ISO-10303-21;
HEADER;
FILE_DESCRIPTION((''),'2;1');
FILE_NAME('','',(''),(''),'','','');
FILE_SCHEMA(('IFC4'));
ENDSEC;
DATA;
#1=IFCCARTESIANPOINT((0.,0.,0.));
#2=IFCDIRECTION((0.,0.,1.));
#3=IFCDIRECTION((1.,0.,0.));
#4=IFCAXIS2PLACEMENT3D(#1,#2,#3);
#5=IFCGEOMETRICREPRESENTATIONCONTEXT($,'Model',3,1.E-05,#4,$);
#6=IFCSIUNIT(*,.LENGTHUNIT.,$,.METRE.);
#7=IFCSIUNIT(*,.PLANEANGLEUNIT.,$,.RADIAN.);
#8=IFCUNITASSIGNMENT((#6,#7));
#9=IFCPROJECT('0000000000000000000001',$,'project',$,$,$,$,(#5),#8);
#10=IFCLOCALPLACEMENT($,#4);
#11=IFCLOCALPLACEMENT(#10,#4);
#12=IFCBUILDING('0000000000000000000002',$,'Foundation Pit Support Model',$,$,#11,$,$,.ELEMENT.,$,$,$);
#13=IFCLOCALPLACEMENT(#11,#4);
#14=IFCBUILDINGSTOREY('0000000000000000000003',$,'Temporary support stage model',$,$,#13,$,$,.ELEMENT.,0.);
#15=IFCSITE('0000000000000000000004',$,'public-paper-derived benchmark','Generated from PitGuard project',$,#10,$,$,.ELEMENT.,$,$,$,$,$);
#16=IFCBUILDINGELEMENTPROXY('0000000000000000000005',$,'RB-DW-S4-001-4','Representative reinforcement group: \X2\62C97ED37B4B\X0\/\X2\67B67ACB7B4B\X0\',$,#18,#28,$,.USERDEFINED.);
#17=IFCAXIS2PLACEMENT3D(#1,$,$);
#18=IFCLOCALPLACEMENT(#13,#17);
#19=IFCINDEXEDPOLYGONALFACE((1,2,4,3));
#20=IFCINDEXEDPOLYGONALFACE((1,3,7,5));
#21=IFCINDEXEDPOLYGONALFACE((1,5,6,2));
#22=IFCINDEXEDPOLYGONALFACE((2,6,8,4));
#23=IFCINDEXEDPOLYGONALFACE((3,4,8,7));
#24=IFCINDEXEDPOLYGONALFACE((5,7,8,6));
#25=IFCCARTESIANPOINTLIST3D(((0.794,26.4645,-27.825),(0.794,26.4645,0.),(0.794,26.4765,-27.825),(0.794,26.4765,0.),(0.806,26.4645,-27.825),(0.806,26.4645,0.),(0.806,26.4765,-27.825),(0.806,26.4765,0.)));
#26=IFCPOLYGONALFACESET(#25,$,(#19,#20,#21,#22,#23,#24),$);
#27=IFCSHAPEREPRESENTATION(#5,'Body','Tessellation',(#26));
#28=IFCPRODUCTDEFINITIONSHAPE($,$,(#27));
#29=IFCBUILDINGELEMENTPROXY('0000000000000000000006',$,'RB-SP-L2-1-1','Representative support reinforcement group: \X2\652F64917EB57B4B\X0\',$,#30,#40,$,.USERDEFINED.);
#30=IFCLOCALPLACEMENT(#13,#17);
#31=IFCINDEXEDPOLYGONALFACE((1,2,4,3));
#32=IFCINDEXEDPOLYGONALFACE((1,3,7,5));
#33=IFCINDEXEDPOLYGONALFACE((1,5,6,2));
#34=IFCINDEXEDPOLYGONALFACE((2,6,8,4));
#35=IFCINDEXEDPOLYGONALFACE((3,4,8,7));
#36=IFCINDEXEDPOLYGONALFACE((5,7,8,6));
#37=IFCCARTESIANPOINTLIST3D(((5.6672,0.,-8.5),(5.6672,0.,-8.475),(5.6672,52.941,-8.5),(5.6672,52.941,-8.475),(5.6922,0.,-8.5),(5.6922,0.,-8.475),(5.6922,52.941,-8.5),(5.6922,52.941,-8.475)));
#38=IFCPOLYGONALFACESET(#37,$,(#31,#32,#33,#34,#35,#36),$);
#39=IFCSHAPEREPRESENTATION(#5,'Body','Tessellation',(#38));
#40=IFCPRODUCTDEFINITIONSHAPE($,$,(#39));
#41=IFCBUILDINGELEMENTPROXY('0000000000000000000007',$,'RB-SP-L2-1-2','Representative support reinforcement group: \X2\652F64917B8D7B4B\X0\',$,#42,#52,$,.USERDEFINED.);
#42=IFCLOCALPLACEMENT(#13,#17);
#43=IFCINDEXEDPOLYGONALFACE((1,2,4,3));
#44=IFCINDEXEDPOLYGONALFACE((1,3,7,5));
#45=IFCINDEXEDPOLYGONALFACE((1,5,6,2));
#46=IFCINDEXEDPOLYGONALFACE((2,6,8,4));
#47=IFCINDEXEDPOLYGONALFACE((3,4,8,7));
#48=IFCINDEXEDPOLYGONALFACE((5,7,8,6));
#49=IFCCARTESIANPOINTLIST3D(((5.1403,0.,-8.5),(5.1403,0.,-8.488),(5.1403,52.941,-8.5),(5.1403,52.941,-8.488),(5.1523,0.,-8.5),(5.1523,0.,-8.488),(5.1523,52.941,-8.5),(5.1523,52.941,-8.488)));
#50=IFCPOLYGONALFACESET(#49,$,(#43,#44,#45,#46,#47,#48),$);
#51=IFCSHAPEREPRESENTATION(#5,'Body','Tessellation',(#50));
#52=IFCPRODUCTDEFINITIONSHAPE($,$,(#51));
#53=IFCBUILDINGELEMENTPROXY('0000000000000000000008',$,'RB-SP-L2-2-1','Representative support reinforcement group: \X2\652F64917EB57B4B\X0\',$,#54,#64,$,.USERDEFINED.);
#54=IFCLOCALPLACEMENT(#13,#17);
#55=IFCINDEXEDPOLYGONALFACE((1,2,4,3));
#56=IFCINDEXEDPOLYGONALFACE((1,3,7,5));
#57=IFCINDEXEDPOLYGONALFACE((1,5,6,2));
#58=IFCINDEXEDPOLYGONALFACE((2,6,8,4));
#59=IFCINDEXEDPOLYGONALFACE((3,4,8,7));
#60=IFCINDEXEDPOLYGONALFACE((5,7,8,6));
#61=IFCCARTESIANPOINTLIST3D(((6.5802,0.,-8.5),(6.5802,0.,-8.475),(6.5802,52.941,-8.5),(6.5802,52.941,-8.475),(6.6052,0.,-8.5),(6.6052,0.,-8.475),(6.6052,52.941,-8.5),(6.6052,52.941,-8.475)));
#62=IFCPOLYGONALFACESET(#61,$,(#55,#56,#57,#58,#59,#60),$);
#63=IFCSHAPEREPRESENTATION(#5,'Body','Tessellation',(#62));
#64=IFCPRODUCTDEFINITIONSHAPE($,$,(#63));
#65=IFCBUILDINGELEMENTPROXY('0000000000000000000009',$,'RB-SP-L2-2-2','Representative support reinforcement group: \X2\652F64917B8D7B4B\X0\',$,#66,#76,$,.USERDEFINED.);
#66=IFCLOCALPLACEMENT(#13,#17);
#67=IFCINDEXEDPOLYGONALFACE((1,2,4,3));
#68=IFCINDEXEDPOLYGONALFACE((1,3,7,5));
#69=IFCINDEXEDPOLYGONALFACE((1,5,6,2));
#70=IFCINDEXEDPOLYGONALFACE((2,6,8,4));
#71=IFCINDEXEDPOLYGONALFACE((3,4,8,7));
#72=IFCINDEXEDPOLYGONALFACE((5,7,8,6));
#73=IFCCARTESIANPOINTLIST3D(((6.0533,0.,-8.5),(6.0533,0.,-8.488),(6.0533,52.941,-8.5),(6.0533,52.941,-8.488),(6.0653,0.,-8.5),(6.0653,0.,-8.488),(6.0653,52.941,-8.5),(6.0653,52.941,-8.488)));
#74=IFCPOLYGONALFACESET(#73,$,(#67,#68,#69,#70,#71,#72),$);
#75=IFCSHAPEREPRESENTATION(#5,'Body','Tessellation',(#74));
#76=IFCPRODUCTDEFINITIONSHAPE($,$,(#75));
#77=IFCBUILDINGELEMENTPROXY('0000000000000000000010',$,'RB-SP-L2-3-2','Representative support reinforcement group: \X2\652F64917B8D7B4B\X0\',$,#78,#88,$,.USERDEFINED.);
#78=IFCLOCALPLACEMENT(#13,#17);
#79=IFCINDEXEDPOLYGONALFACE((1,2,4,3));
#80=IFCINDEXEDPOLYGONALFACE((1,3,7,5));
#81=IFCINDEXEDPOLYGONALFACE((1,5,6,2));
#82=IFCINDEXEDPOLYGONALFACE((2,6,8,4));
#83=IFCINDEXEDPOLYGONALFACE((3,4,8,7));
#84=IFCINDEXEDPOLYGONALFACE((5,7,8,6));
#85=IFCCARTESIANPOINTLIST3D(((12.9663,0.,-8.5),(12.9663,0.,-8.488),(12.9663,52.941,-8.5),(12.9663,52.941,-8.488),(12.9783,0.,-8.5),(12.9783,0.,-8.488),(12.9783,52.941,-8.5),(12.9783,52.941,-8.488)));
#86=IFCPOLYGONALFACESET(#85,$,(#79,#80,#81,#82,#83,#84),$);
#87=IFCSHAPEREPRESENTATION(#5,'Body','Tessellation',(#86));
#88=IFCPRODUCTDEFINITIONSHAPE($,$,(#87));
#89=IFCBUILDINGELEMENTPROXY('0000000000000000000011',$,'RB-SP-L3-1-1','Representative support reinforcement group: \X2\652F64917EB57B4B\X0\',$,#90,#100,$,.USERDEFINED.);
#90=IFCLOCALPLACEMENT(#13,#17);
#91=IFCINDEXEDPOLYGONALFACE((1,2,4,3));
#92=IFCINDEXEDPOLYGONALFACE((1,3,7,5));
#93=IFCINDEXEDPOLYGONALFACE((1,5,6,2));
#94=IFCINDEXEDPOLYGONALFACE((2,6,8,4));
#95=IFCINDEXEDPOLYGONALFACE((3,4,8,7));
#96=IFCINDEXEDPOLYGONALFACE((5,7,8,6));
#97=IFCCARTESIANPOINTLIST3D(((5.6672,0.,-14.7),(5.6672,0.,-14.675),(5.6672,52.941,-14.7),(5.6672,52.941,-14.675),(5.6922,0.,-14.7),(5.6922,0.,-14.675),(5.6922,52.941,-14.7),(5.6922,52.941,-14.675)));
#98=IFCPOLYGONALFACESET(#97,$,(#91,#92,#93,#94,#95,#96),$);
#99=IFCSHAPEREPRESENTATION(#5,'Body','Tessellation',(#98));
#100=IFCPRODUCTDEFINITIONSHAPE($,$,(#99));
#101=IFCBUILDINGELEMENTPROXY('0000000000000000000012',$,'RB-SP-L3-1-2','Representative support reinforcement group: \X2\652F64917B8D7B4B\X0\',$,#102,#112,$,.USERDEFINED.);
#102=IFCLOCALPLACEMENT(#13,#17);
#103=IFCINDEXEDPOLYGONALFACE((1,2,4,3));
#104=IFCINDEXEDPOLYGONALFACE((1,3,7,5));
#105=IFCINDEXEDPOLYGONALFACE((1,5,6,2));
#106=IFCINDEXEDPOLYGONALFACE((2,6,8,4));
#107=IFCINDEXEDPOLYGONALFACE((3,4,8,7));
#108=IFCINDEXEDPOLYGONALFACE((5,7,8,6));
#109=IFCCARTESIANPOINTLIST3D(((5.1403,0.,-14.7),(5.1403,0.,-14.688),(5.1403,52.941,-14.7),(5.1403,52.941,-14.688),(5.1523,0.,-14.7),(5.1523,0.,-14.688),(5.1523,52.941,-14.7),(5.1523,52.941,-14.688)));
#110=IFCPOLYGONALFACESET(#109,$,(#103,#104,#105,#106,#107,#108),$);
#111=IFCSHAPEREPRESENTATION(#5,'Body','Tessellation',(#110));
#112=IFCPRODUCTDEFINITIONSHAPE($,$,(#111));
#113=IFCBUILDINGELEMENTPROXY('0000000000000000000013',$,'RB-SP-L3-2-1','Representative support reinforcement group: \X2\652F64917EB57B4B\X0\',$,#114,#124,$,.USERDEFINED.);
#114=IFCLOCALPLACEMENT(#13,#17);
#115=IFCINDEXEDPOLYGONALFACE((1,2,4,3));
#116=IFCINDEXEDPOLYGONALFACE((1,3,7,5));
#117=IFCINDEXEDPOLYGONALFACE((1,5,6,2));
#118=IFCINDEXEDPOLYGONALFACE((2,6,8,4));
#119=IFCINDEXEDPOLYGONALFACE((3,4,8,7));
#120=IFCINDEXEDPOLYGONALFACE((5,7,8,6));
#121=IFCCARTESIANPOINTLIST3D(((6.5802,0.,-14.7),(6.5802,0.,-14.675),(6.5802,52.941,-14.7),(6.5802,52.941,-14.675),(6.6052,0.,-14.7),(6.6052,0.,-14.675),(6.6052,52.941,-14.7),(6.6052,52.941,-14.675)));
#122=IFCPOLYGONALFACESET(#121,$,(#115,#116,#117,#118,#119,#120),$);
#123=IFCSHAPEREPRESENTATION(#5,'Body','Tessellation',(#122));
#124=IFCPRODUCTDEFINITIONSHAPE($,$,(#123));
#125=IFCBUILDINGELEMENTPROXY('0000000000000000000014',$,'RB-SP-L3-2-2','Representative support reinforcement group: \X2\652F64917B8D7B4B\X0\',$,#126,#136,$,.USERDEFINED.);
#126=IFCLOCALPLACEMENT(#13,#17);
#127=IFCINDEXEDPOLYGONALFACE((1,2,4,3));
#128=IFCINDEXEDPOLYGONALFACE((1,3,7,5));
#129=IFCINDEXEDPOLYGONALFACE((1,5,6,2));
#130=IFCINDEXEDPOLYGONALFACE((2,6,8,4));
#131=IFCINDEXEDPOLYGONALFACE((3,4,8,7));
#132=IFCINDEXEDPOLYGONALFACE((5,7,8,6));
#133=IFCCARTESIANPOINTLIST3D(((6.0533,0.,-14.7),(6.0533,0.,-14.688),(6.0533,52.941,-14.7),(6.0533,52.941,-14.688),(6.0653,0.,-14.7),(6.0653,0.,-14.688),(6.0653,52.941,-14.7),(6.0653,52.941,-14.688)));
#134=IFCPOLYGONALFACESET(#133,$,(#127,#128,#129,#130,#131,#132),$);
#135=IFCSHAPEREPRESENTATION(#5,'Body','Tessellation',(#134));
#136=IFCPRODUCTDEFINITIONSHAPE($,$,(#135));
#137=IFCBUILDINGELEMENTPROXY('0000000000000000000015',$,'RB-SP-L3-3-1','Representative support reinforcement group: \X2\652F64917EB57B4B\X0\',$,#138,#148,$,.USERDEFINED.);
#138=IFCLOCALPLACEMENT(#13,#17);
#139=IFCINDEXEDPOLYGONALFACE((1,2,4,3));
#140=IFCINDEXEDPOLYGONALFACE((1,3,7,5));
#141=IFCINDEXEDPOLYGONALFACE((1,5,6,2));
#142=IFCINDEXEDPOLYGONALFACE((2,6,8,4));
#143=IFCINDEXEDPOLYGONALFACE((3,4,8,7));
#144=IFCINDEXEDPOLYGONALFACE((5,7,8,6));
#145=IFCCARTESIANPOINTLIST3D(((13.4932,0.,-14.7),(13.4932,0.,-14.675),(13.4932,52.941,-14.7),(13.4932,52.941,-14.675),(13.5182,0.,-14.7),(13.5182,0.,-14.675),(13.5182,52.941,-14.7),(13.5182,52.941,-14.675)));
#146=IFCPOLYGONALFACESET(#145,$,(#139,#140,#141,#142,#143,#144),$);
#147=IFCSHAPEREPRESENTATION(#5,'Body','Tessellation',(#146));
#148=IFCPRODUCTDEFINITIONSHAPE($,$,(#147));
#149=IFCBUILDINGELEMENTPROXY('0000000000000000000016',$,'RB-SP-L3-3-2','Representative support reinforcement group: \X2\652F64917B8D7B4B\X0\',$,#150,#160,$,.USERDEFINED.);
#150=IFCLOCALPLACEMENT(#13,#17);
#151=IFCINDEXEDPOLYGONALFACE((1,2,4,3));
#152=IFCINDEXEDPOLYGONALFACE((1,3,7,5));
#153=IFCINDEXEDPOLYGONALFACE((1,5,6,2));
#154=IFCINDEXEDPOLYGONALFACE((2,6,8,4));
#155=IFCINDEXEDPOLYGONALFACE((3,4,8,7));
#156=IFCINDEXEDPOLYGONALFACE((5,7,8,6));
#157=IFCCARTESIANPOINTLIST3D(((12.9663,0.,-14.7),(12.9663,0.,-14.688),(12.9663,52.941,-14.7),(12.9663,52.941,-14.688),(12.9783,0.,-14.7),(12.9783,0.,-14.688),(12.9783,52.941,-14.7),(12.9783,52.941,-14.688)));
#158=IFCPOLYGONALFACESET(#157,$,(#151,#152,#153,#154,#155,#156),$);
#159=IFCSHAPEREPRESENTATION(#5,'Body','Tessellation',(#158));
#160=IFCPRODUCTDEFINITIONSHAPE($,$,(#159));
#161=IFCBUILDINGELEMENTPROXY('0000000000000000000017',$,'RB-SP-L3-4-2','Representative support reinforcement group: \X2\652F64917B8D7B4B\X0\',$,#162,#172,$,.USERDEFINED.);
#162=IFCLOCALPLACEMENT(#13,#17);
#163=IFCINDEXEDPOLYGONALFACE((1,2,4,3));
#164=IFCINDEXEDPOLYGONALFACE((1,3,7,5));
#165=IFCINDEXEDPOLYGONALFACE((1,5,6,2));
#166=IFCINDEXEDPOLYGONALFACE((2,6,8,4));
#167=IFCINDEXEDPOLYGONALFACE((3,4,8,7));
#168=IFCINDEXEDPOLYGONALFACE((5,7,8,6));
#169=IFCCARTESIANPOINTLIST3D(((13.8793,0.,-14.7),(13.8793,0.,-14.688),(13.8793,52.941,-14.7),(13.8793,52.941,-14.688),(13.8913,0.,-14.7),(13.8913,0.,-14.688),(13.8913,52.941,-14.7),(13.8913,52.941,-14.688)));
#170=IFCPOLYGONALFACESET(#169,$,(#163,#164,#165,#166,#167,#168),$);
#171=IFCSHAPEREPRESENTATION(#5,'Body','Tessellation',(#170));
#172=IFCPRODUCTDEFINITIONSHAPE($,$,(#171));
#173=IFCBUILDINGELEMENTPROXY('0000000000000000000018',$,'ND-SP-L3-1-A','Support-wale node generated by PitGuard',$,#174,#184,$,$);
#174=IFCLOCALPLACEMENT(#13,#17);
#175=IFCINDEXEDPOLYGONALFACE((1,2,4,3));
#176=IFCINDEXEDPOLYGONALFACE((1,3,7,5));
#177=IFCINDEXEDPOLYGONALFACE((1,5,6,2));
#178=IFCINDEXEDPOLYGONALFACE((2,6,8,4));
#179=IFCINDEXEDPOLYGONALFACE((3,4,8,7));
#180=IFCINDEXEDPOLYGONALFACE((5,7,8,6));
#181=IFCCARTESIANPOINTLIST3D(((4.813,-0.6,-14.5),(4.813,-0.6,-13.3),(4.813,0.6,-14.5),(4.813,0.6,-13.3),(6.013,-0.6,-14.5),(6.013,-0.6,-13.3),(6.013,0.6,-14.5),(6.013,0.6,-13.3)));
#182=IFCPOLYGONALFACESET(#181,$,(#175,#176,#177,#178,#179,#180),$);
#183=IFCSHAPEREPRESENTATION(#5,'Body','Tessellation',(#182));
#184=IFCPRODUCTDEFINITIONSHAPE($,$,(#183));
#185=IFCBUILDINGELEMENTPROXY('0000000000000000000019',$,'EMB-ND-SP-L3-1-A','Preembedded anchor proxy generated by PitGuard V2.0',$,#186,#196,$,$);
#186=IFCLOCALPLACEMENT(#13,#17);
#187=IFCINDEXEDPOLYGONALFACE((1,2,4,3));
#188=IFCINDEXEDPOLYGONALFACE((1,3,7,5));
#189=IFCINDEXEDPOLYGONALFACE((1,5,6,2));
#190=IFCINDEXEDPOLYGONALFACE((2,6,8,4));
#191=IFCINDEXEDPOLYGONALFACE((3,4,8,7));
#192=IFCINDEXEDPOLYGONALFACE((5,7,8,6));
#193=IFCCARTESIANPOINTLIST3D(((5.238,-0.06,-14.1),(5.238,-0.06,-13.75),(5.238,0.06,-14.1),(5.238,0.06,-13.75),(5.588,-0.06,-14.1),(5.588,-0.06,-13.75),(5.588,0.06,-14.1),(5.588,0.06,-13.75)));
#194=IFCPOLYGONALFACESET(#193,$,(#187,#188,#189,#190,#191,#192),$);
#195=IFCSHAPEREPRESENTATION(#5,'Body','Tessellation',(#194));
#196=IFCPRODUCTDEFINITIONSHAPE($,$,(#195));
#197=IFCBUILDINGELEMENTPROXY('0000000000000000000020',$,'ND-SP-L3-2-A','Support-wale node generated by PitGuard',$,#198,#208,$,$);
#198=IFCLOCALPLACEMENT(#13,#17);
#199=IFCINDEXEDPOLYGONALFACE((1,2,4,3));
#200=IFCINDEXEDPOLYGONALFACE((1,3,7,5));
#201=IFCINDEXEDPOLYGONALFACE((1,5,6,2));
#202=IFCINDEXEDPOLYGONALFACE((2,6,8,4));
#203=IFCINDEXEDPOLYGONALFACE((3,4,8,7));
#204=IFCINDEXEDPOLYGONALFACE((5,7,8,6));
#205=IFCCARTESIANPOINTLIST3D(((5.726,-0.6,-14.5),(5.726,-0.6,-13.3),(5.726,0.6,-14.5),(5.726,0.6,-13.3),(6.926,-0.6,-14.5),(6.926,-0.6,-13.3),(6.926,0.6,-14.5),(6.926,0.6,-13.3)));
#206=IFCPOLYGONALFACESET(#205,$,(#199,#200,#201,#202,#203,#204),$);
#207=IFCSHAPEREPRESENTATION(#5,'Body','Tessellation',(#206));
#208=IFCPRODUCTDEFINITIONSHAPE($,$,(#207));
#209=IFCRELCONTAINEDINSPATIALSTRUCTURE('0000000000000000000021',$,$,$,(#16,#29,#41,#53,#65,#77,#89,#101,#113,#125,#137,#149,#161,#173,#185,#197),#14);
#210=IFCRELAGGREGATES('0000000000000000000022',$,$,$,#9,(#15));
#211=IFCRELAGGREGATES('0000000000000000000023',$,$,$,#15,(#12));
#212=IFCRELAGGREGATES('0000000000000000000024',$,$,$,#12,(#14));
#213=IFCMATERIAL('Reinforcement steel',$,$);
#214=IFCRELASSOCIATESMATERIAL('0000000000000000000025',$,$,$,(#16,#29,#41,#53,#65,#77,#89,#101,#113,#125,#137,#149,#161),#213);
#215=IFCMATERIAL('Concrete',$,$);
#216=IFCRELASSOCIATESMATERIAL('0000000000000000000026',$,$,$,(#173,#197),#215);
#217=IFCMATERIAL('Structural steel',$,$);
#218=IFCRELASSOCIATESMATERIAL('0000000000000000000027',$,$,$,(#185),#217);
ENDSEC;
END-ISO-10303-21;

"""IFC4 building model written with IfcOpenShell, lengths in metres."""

from ifc_helpers import new_model, si_unit, frame, origin_with_axes, origin_2d, place, context, project, spatial, rectangle, extrude, material, element, save


model = new_model("IFC4")

# Units and contexts
model_context = context("Model", 3, precision=1e-05, world=origin_with_axes())
ifc_project = project(units=[si_unit("LENGTHUNIT", "METRE"), si_unit("PLANEANGLEUNIT", "RADIAN")], contexts=[model_context])

# Site, building, storey
site_placement = place(None, origin_with_axes())
site = spatial("IfcSite", under=ifc_project, at=site_placement, Name="public-paper-derived benchmark", Description="Generated from PitGuard project", CompositionType="ELEMENT")
building_placement = place(site_placement, origin_with_axes())
building = spatial("IfcBuilding", under=site, at=building_placement, Name="Foundation Pit Support Model", CompositionType="ELEMENT")
storey_placement = place(building_placement, origin_with_axes())
storey = spatial("IfcBuildingStorey", under=building, at=storey_placement, Name="Temporary support stage model", CompositionType="ELEMENT", Elevation=0.0)

# Shared definitions
ifc_material_1 = material(Name="Structural steel")

# Shared definitions
ifc_material_2 = material(Name="Concrete")

# Building element proxies
ifc_material_3 = material(Name="Reinforcement steel")
proxy_1_placement = place(storey_placement, frame((0.8, 26.4705, -27.825), z_axis=(0.0, 0.0, 1.0), x_axis=(1.0, 0.0, 0.0)))
element("IfcBuildingElementProxy", 1, at=proxy_1_placement, inside=storey, material=ifc_material_3, Name="RB-DW-S4-001-4", Description="Representative reinforcement group: 拉结筋/架立筋", PredefinedType="USERDEFINED", context=model_context, shape_type="SweptSolid", body=[
    extrude(rectangle(XDim=0.012, YDim=0.012, at=origin_2d()), origin_with_axes(), (0.0, 0.0, 1.0), 27.825),
])
proxy_2_placement = place(storey_placement, frame((5.6797, 26.4705, -8.5), z_axis=(0.0, 0.0, 1.0), x_axis=(0.0, 1.0, 0.0)))
element("IfcBuildingElementProxy", 2, at=proxy_2_placement, inside=storey, material=ifc_material_3, Name="RB-SP-L2-1-1", Description="Representative support reinforcement group: 支撑纵筋", PredefinedType="USERDEFINED", context=model_context, shape_type="SweptSolid", body=[
    extrude(rectangle(XDim=52.941, YDim=0.025, at=origin_2d()), origin_with_axes(), (0.0, 0.0, 1.0), 0.025),
])
proxy_3_placement = place(storey_placement, frame((5.1463, 26.4705, -8.5), z_axis=(0.0, 0.0, 1.0), x_axis=(0.0, 1.0, 0.0)))
element("IfcBuildingElementProxy", 3, at=proxy_3_placement, inside=storey, material=ifc_material_3, Name="RB-SP-L2-1-2", Description="Representative support reinforcement group: 支撑箍筋", PredefinedType="USERDEFINED", context=model_context, shape_type="SweptSolid", body=[
    extrude(rectangle(XDim=52.941, YDim=0.012, at=origin_2d()), origin_with_axes(), (0.0, 0.0, 1.0), 0.012),
])
proxy_4_placement = place(storey_placement, frame((6.5927, 26.4705, -8.5), z_axis=(0.0, 0.0, 1.0), x_axis=(0.0, 1.0, 0.0)))
element("IfcBuildingElementProxy", 4, at=proxy_4_placement, inside=storey, material=ifc_material_3, Name="RB-SP-L2-2-1", Description="Representative support reinforcement group: 支撑纵筋", PredefinedType="USERDEFINED", context=model_context, shape_type="SweptSolid", body=[
    extrude(rectangle(XDim=52.941, YDim=0.025, at=origin_2d()), origin_with_axes(), (0.0, 0.0, 1.0), 0.025),
])
for number, where, z_axis, x_axis, name in (
    (5, (6.0593, 26.4705, -8.5), (0.0, 0.0, 1.0), (0.0, 1.0, 0.0), "RB-SP-L2-2-2"),
    (6, (12.9723, 26.4705, -8.5), (0.0, 0.0, 1.0), (0.0, 1.0, 0.0), "RB-SP-L2-3-2"),
):
    element("IfcBuildingElementProxy", number, at=place(storey_placement, frame(where, z_axis=z_axis, x_axis=x_axis)), inside=storey, material=ifc_material_3, Name=name, Description="Representative support reinforcement group: 支撑箍筋", PredefinedType="USERDEFINED", context=model_context, shape_type="SweptSolid", body=[
        extrude(rectangle(XDim=52.941, YDim=0.012, at=origin_2d()), origin_with_axes(), (0.0, 0.0, 1.0), 0.012),
    ])
proxy_5_placement = place(storey_placement, frame((5.6797, 26.4705, -14.7), z_axis=(0.0, 0.0, 1.0), x_axis=(0.0, 1.0, 0.0)))
element("IfcBuildingElementProxy", 7, at=proxy_5_placement, inside=storey, material=ifc_material_3, Name="RB-SP-L3-1-1", Description="Representative support reinforcement group: 支撑纵筋", PredefinedType="USERDEFINED", context=model_context, shape_type="SweptSolid", body=[
    extrude(rectangle(XDim=52.941, YDim=0.025, at=origin_2d()), origin_with_axes(), (0.0, 0.0, 1.0), 0.025),
])
proxy_6_placement = place(storey_placement, frame((5.1463, 26.4705, -14.7), z_axis=(0.0, 0.0, 1.0), x_axis=(0.0, 1.0, 0.0)))
element("IfcBuildingElementProxy", 8, at=proxy_6_placement, inside=storey, material=ifc_material_3, Name="RB-SP-L3-1-2", Description="Representative support reinforcement group: 支撑箍筋", PredefinedType="USERDEFINED", context=model_context, shape_type="SweptSolid", body=[
    extrude(rectangle(XDim=52.941, YDim=0.012, at=origin_2d()), origin_with_axes(), (0.0, 0.0, 1.0), 0.012),
])
proxy_7_placement = place(storey_placement, frame((6.5927, 26.4705, -14.7), z_axis=(0.0, 0.0, 1.0), x_axis=(0.0, 1.0, 0.0)))
element("IfcBuildingElementProxy", 9, at=proxy_7_placement, inside=storey, material=ifc_material_3, Name="RB-SP-L3-2-1", Description="Representative support reinforcement group: 支撑纵筋", PredefinedType="USERDEFINED", context=model_context, shape_type="SweptSolid", body=[
    extrude(rectangle(XDim=52.941, YDim=0.025, at=origin_2d()), origin_with_axes(), (0.0, 0.0, 1.0), 0.025),
])
proxy_8_placement = place(storey_placement, frame((6.0593, 26.4705, -14.7), z_axis=(0.0, 0.0, 1.0), x_axis=(0.0, 1.0, 0.0)))
element("IfcBuildingElementProxy", 10, at=proxy_8_placement, inside=storey, material=ifc_material_3, Name="RB-SP-L3-2-2", Description="Representative support reinforcement group: 支撑箍筋", PredefinedType="USERDEFINED", context=model_context, shape_type="SweptSolid", body=[
    extrude(rectangle(XDim=52.941, YDim=0.012, at=origin_2d()), origin_with_axes(), (0.0, 0.0, 1.0), 0.012),
])
proxy_9_placement = place(storey_placement, frame((13.5057, 26.4705, -14.7), z_axis=(0.0, 0.0, 1.0), x_axis=(0.0, 1.0, 0.0)))
element("IfcBuildingElementProxy", 11, at=proxy_9_placement, inside=storey, material=ifc_material_3, Name="RB-SP-L3-3-1", Description="Representative support reinforcement group: 支撑纵筋", PredefinedType="USERDEFINED", context=model_context, shape_type="SweptSolid", body=[
    extrude(rectangle(XDim=52.941, YDim=0.025, at=origin_2d()), origin_with_axes(), (0.0, 0.0, 1.0), 0.025),
])
for number, where, z_axis, x_axis, name in (
    (12, (12.9723, 26.4705, -14.7), (0.0, 0.0, 1.0), (0.0, 1.0, 0.0), "RB-SP-L3-3-2"),
    (13, (13.8853, 26.4705, -14.7), (0.0, 0.0, 1.0), (0.0, 1.0, 0.0), "RB-SP-L3-4-2"),
):
    element("IfcBuildingElementProxy", number, at=place(storey_placement, frame(where, z_axis=z_axis, x_axis=x_axis)), inside=storey, material=ifc_material_3, Name=name, Description="Representative support reinforcement group: 支撑箍筋", PredefinedType="USERDEFINED", context=model_context, shape_type="SweptSolid", body=[
        extrude(rectangle(XDim=52.941, YDim=0.012, at=origin_2d()), origin_with_axes(), (0.0, 0.0, 1.0), 0.012),
    ])
proxy_10_placement = place(storey_placement, frame((5.413, 0.0, -14.5), z_axis=(0.0, 0.0, 1.0), x_axis=(1.0, 0.0, 0.0)))
element("IfcBuildingElementProxy", 14, at=proxy_10_placement, inside=storey, material=ifc_material_2, Name="ND-SP-L3-1-A", Description="Support-wale node generated by PitGuard", context=model_context, shape_type="SweptSolid", body=[
    extrude(rectangle(XDim=1.2, YDim=1.2, at=origin_2d()), origin_with_axes(), (0.0, 0.0, 1.0), 1.2),
])
proxy_11_placement = place(storey_placement, frame((5.413, 0.0, -14.1), z_axis=(0.0, 0.0, 1.0), x_axis=(1.0, 0.0, 0.0)))
element("IfcBuildingElementProxy", 15, at=proxy_11_placement, inside=storey, material=ifc_material_1, Name="EMB-ND-SP-L3-1-A", Description="Preembedded anchor proxy generated by PitGuard V2.0", context=model_context, shape_type="SweptSolid", body=[
    extrude(rectangle(XDim=0.35, YDim=0.12, at=origin_2d()), origin_with_axes(), (0.0, 0.0, 1.0), 0.35),
])
proxy_12_placement = place(storey_placement, frame((6.326, 0.0, -14.5), z_axis=(0.0, 0.0, 1.0), x_axis=(1.0, 0.0, 0.0)))
element("IfcBuildingElementProxy", 16, at=proxy_12_placement, inside=storey, material=ifc_material_2, Name="ND-SP-L3-2-A", Description="Support-wale node generated by PitGuard", context=model_context, shape_type="SweptSolid", body=[
    extrude(rectangle(XDim=1.2, YDim=1.2, at=origin_2d()), origin_with_axes(), (0.0, 0.0, 1.0), 1.2),
])

save(model, "model.ifc")
